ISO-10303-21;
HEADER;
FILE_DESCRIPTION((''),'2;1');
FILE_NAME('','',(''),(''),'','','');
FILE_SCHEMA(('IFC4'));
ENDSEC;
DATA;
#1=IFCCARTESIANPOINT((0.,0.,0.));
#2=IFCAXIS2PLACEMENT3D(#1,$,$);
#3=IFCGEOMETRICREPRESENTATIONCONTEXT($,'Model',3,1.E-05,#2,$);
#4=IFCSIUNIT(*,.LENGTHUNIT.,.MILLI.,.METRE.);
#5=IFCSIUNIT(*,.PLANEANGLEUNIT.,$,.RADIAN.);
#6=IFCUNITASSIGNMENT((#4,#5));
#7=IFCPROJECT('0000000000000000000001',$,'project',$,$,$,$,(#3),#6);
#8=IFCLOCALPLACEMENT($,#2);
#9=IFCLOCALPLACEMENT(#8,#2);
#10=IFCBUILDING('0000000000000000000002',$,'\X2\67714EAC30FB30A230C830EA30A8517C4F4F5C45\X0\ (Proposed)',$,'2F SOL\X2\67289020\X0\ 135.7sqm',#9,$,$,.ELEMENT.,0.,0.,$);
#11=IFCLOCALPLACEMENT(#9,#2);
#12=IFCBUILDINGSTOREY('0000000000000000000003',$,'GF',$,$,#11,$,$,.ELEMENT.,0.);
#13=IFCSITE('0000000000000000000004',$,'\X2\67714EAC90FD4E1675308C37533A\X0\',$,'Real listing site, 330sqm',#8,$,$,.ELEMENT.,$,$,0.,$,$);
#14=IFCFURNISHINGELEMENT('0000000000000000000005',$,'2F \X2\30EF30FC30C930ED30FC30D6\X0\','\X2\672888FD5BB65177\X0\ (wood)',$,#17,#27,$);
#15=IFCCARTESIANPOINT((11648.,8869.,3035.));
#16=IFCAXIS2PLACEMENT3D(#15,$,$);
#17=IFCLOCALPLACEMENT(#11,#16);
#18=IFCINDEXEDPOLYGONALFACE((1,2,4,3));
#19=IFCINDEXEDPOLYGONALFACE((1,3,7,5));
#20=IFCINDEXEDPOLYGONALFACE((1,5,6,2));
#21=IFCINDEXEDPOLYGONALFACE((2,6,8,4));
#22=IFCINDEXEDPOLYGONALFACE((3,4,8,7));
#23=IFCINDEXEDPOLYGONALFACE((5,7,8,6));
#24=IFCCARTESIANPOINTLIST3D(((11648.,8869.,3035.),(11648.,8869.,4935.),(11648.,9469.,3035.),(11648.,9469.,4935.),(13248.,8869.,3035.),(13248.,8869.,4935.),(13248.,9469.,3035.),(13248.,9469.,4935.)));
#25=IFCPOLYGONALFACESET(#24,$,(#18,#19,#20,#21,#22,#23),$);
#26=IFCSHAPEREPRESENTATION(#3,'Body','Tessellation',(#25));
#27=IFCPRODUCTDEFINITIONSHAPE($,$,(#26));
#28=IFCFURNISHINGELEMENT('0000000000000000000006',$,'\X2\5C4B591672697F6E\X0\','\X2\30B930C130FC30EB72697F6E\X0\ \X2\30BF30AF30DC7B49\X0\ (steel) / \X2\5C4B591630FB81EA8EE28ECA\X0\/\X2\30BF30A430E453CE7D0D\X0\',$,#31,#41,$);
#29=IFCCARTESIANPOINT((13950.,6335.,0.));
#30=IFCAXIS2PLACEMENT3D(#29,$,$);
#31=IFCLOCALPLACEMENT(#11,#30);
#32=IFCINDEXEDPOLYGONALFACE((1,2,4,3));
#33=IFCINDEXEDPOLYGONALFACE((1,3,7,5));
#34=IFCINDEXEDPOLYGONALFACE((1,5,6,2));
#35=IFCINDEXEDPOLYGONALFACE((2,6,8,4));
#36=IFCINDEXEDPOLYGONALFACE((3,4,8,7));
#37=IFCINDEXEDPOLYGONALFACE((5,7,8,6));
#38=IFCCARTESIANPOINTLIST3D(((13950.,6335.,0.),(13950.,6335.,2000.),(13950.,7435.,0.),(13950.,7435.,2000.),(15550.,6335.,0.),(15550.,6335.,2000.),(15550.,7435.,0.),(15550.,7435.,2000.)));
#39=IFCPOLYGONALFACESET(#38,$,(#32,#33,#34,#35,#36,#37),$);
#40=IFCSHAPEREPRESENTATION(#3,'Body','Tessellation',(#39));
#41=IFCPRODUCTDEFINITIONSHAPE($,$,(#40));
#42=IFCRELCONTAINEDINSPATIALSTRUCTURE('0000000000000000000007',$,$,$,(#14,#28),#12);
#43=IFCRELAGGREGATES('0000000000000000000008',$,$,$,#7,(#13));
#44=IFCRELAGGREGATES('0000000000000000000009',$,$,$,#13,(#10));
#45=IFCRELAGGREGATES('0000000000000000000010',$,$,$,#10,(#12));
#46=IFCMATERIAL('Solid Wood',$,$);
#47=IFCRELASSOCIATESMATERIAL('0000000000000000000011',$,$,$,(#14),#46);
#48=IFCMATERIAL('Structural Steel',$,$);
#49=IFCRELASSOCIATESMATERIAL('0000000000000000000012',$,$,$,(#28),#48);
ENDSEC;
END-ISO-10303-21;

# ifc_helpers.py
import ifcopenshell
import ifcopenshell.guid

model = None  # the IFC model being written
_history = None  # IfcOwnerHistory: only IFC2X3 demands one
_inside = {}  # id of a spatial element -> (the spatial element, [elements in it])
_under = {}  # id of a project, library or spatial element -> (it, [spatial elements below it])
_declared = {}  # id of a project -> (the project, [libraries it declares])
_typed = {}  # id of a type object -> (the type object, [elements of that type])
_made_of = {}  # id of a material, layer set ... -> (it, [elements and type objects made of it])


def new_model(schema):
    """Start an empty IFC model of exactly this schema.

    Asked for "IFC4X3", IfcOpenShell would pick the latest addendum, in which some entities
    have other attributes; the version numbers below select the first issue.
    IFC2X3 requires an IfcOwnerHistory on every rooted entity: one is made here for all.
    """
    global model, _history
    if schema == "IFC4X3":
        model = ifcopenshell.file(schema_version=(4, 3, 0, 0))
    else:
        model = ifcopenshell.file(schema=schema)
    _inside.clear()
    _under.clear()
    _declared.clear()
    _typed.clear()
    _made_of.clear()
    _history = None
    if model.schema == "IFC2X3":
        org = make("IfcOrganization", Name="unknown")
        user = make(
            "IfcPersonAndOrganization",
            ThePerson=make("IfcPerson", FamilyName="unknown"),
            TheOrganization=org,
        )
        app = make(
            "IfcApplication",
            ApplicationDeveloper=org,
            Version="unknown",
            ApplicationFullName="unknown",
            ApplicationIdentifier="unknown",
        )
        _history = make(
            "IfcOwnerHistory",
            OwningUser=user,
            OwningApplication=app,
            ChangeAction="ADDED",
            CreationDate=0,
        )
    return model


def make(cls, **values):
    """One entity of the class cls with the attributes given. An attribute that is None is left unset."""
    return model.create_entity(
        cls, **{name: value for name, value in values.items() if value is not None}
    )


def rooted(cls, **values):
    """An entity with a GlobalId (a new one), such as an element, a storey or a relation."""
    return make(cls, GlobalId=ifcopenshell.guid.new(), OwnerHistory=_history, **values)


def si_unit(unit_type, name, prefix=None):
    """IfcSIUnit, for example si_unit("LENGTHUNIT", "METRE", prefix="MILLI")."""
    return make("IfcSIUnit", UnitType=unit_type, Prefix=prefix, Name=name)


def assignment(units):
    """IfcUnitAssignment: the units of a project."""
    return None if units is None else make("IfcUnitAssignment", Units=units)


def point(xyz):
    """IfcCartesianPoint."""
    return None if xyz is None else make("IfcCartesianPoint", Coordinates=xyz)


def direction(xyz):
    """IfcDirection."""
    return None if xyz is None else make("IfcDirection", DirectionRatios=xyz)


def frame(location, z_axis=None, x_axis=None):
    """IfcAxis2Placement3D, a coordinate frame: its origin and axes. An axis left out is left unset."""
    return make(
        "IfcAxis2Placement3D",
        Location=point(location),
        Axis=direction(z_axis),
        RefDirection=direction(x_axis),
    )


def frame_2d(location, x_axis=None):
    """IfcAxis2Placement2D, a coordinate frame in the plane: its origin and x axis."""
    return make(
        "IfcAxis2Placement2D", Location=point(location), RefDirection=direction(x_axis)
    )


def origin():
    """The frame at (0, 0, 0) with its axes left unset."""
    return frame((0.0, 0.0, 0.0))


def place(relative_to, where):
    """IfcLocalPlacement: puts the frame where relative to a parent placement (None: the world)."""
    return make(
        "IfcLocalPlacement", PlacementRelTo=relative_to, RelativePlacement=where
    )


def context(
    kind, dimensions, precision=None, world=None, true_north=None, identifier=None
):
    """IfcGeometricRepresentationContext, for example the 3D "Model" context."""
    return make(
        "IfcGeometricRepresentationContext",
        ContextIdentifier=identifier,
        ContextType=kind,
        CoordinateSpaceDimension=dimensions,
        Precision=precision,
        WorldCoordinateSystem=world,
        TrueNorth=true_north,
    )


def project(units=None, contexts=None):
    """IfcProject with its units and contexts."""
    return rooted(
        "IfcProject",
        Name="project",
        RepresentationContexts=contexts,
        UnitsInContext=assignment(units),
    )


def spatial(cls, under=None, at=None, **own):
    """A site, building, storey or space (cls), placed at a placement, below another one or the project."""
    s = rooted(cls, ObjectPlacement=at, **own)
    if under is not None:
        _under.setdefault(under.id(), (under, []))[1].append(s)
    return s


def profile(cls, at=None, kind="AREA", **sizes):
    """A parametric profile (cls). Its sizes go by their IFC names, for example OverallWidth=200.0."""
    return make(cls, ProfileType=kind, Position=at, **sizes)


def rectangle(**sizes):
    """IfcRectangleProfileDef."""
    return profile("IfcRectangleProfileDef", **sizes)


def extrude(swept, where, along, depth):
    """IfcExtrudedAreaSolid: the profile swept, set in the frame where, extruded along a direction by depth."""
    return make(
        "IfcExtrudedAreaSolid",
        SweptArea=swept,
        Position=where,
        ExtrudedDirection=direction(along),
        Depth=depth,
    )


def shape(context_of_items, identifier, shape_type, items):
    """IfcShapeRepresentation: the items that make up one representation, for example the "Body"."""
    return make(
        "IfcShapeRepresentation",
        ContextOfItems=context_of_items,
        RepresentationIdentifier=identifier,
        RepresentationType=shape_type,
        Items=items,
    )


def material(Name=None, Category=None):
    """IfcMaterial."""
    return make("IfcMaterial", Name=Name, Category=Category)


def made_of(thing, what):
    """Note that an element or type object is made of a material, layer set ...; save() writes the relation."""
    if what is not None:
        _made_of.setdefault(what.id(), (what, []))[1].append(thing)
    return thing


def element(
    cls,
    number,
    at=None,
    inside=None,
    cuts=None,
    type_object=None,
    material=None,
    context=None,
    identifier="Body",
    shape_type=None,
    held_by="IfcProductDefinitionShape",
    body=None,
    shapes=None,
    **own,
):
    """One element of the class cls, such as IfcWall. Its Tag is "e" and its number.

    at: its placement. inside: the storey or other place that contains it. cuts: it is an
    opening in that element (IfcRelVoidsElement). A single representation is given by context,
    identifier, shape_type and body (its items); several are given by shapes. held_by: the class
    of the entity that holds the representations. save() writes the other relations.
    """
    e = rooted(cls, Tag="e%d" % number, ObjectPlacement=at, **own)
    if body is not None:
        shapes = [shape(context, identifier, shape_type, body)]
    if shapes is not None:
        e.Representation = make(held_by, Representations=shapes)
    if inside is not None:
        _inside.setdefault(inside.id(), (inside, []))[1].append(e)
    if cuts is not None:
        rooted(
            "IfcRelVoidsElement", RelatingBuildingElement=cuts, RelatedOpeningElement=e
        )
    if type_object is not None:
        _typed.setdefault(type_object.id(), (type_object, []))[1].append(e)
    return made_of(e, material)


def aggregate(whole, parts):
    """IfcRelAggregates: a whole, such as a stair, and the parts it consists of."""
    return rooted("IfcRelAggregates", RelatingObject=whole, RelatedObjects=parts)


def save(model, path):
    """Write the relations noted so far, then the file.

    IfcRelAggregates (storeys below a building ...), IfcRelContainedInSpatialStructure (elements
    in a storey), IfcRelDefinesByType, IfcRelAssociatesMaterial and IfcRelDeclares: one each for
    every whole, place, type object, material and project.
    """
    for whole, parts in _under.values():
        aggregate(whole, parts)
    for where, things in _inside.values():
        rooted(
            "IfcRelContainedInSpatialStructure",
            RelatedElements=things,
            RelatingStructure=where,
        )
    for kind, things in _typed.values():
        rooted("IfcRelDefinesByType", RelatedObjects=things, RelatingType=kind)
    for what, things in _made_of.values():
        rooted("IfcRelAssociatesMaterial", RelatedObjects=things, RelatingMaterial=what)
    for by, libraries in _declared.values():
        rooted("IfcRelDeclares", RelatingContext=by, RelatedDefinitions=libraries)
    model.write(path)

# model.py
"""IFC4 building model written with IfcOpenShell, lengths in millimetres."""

from ifc_helpers import new_model, si_unit, frame, frame_2d, origin, place, context, project, spatial, rectangle, extrude, material, element, save


model = new_model("IFC4")

# Units and contexts
model_context = context("Model", 3, precision=1e-05, world=origin())
ifc_project = project(units=[si_unit("LENGTHUNIT", "METRE", prefix="MILLI"), si_unit("PLANEANGLEUNIT", "RADIAN")], contexts=[model_context])

# Site, building, storey
site_placement = place(None, origin())
site = spatial("IfcSite", under=ifc_project, at=site_placement, Name="東京都世田谷区", ObjectType="Real listing site, 330sqm", CompositionType="ELEMENT", RefElevation=0.0)
building_placement = place(site_placement, origin())
building = spatial("IfcBuilding", under=site, at=building_placement, Name="東京・アトリエ兼住居 (Proposed)", ObjectType="2F SOL木造 135.7sqm", CompositionType="ELEMENT", ElevationOfRefHeight=0.0, ElevationOfTerrain=0.0)
storey_placement = place(building_placement, origin())
storey = spatial("IfcBuildingStorey", under=building, at=storey_placement, Name="GF", CompositionType="ELEMENT", Elevation=0.0)

# Shared definitions
ifc_material_1 = material(Name="Solid Wood")

# Shared definitions
ifc_material_2 = material(Name="Structural Steel")

# Furnishing elements
furnishing_1_placement = place(storey_placement, frame((11648.0, 8869.0, 3035.0)))
element("IfcFurnishingElement", 1, at=furnishing_1_placement, inside=storey, material=ifc_material_1, Name="2F ワードローブ", Description="木製家具 (wood)", context=model_context, shape_type="SweptSolid", body=[
    extrude(rectangle(XDim=1600.0, YDim=600.0, at=frame_2d((800.0, 300.0))), frame((11648.0, 8869.0, 3035.0)), (0.0, 0.0, 1.0), 1900.0),
])
furnishing_2_placement = place(storey_placement, frame((13950.0, 6335.0, 0.0)))
element("IfcFurnishingElement", 2, at=furnishing_2_placement, inside=storey, material=ifc_material_2, Name="屋外物置", Description="スチール物置 タクボ等 (steel) / 屋外・自転車/タイヤ収納", context=model_context, shape_type="SweptSolid", body=[
    extrude(rectangle(XDim=1600.0, YDim=1100.0, at=frame_2d((800.0, 550.0))), frame((13950.0, 6335.0, 0.0)), (0.0, 0.0, 1.0), 2000.0),
])

save(model, "model.ifc")
